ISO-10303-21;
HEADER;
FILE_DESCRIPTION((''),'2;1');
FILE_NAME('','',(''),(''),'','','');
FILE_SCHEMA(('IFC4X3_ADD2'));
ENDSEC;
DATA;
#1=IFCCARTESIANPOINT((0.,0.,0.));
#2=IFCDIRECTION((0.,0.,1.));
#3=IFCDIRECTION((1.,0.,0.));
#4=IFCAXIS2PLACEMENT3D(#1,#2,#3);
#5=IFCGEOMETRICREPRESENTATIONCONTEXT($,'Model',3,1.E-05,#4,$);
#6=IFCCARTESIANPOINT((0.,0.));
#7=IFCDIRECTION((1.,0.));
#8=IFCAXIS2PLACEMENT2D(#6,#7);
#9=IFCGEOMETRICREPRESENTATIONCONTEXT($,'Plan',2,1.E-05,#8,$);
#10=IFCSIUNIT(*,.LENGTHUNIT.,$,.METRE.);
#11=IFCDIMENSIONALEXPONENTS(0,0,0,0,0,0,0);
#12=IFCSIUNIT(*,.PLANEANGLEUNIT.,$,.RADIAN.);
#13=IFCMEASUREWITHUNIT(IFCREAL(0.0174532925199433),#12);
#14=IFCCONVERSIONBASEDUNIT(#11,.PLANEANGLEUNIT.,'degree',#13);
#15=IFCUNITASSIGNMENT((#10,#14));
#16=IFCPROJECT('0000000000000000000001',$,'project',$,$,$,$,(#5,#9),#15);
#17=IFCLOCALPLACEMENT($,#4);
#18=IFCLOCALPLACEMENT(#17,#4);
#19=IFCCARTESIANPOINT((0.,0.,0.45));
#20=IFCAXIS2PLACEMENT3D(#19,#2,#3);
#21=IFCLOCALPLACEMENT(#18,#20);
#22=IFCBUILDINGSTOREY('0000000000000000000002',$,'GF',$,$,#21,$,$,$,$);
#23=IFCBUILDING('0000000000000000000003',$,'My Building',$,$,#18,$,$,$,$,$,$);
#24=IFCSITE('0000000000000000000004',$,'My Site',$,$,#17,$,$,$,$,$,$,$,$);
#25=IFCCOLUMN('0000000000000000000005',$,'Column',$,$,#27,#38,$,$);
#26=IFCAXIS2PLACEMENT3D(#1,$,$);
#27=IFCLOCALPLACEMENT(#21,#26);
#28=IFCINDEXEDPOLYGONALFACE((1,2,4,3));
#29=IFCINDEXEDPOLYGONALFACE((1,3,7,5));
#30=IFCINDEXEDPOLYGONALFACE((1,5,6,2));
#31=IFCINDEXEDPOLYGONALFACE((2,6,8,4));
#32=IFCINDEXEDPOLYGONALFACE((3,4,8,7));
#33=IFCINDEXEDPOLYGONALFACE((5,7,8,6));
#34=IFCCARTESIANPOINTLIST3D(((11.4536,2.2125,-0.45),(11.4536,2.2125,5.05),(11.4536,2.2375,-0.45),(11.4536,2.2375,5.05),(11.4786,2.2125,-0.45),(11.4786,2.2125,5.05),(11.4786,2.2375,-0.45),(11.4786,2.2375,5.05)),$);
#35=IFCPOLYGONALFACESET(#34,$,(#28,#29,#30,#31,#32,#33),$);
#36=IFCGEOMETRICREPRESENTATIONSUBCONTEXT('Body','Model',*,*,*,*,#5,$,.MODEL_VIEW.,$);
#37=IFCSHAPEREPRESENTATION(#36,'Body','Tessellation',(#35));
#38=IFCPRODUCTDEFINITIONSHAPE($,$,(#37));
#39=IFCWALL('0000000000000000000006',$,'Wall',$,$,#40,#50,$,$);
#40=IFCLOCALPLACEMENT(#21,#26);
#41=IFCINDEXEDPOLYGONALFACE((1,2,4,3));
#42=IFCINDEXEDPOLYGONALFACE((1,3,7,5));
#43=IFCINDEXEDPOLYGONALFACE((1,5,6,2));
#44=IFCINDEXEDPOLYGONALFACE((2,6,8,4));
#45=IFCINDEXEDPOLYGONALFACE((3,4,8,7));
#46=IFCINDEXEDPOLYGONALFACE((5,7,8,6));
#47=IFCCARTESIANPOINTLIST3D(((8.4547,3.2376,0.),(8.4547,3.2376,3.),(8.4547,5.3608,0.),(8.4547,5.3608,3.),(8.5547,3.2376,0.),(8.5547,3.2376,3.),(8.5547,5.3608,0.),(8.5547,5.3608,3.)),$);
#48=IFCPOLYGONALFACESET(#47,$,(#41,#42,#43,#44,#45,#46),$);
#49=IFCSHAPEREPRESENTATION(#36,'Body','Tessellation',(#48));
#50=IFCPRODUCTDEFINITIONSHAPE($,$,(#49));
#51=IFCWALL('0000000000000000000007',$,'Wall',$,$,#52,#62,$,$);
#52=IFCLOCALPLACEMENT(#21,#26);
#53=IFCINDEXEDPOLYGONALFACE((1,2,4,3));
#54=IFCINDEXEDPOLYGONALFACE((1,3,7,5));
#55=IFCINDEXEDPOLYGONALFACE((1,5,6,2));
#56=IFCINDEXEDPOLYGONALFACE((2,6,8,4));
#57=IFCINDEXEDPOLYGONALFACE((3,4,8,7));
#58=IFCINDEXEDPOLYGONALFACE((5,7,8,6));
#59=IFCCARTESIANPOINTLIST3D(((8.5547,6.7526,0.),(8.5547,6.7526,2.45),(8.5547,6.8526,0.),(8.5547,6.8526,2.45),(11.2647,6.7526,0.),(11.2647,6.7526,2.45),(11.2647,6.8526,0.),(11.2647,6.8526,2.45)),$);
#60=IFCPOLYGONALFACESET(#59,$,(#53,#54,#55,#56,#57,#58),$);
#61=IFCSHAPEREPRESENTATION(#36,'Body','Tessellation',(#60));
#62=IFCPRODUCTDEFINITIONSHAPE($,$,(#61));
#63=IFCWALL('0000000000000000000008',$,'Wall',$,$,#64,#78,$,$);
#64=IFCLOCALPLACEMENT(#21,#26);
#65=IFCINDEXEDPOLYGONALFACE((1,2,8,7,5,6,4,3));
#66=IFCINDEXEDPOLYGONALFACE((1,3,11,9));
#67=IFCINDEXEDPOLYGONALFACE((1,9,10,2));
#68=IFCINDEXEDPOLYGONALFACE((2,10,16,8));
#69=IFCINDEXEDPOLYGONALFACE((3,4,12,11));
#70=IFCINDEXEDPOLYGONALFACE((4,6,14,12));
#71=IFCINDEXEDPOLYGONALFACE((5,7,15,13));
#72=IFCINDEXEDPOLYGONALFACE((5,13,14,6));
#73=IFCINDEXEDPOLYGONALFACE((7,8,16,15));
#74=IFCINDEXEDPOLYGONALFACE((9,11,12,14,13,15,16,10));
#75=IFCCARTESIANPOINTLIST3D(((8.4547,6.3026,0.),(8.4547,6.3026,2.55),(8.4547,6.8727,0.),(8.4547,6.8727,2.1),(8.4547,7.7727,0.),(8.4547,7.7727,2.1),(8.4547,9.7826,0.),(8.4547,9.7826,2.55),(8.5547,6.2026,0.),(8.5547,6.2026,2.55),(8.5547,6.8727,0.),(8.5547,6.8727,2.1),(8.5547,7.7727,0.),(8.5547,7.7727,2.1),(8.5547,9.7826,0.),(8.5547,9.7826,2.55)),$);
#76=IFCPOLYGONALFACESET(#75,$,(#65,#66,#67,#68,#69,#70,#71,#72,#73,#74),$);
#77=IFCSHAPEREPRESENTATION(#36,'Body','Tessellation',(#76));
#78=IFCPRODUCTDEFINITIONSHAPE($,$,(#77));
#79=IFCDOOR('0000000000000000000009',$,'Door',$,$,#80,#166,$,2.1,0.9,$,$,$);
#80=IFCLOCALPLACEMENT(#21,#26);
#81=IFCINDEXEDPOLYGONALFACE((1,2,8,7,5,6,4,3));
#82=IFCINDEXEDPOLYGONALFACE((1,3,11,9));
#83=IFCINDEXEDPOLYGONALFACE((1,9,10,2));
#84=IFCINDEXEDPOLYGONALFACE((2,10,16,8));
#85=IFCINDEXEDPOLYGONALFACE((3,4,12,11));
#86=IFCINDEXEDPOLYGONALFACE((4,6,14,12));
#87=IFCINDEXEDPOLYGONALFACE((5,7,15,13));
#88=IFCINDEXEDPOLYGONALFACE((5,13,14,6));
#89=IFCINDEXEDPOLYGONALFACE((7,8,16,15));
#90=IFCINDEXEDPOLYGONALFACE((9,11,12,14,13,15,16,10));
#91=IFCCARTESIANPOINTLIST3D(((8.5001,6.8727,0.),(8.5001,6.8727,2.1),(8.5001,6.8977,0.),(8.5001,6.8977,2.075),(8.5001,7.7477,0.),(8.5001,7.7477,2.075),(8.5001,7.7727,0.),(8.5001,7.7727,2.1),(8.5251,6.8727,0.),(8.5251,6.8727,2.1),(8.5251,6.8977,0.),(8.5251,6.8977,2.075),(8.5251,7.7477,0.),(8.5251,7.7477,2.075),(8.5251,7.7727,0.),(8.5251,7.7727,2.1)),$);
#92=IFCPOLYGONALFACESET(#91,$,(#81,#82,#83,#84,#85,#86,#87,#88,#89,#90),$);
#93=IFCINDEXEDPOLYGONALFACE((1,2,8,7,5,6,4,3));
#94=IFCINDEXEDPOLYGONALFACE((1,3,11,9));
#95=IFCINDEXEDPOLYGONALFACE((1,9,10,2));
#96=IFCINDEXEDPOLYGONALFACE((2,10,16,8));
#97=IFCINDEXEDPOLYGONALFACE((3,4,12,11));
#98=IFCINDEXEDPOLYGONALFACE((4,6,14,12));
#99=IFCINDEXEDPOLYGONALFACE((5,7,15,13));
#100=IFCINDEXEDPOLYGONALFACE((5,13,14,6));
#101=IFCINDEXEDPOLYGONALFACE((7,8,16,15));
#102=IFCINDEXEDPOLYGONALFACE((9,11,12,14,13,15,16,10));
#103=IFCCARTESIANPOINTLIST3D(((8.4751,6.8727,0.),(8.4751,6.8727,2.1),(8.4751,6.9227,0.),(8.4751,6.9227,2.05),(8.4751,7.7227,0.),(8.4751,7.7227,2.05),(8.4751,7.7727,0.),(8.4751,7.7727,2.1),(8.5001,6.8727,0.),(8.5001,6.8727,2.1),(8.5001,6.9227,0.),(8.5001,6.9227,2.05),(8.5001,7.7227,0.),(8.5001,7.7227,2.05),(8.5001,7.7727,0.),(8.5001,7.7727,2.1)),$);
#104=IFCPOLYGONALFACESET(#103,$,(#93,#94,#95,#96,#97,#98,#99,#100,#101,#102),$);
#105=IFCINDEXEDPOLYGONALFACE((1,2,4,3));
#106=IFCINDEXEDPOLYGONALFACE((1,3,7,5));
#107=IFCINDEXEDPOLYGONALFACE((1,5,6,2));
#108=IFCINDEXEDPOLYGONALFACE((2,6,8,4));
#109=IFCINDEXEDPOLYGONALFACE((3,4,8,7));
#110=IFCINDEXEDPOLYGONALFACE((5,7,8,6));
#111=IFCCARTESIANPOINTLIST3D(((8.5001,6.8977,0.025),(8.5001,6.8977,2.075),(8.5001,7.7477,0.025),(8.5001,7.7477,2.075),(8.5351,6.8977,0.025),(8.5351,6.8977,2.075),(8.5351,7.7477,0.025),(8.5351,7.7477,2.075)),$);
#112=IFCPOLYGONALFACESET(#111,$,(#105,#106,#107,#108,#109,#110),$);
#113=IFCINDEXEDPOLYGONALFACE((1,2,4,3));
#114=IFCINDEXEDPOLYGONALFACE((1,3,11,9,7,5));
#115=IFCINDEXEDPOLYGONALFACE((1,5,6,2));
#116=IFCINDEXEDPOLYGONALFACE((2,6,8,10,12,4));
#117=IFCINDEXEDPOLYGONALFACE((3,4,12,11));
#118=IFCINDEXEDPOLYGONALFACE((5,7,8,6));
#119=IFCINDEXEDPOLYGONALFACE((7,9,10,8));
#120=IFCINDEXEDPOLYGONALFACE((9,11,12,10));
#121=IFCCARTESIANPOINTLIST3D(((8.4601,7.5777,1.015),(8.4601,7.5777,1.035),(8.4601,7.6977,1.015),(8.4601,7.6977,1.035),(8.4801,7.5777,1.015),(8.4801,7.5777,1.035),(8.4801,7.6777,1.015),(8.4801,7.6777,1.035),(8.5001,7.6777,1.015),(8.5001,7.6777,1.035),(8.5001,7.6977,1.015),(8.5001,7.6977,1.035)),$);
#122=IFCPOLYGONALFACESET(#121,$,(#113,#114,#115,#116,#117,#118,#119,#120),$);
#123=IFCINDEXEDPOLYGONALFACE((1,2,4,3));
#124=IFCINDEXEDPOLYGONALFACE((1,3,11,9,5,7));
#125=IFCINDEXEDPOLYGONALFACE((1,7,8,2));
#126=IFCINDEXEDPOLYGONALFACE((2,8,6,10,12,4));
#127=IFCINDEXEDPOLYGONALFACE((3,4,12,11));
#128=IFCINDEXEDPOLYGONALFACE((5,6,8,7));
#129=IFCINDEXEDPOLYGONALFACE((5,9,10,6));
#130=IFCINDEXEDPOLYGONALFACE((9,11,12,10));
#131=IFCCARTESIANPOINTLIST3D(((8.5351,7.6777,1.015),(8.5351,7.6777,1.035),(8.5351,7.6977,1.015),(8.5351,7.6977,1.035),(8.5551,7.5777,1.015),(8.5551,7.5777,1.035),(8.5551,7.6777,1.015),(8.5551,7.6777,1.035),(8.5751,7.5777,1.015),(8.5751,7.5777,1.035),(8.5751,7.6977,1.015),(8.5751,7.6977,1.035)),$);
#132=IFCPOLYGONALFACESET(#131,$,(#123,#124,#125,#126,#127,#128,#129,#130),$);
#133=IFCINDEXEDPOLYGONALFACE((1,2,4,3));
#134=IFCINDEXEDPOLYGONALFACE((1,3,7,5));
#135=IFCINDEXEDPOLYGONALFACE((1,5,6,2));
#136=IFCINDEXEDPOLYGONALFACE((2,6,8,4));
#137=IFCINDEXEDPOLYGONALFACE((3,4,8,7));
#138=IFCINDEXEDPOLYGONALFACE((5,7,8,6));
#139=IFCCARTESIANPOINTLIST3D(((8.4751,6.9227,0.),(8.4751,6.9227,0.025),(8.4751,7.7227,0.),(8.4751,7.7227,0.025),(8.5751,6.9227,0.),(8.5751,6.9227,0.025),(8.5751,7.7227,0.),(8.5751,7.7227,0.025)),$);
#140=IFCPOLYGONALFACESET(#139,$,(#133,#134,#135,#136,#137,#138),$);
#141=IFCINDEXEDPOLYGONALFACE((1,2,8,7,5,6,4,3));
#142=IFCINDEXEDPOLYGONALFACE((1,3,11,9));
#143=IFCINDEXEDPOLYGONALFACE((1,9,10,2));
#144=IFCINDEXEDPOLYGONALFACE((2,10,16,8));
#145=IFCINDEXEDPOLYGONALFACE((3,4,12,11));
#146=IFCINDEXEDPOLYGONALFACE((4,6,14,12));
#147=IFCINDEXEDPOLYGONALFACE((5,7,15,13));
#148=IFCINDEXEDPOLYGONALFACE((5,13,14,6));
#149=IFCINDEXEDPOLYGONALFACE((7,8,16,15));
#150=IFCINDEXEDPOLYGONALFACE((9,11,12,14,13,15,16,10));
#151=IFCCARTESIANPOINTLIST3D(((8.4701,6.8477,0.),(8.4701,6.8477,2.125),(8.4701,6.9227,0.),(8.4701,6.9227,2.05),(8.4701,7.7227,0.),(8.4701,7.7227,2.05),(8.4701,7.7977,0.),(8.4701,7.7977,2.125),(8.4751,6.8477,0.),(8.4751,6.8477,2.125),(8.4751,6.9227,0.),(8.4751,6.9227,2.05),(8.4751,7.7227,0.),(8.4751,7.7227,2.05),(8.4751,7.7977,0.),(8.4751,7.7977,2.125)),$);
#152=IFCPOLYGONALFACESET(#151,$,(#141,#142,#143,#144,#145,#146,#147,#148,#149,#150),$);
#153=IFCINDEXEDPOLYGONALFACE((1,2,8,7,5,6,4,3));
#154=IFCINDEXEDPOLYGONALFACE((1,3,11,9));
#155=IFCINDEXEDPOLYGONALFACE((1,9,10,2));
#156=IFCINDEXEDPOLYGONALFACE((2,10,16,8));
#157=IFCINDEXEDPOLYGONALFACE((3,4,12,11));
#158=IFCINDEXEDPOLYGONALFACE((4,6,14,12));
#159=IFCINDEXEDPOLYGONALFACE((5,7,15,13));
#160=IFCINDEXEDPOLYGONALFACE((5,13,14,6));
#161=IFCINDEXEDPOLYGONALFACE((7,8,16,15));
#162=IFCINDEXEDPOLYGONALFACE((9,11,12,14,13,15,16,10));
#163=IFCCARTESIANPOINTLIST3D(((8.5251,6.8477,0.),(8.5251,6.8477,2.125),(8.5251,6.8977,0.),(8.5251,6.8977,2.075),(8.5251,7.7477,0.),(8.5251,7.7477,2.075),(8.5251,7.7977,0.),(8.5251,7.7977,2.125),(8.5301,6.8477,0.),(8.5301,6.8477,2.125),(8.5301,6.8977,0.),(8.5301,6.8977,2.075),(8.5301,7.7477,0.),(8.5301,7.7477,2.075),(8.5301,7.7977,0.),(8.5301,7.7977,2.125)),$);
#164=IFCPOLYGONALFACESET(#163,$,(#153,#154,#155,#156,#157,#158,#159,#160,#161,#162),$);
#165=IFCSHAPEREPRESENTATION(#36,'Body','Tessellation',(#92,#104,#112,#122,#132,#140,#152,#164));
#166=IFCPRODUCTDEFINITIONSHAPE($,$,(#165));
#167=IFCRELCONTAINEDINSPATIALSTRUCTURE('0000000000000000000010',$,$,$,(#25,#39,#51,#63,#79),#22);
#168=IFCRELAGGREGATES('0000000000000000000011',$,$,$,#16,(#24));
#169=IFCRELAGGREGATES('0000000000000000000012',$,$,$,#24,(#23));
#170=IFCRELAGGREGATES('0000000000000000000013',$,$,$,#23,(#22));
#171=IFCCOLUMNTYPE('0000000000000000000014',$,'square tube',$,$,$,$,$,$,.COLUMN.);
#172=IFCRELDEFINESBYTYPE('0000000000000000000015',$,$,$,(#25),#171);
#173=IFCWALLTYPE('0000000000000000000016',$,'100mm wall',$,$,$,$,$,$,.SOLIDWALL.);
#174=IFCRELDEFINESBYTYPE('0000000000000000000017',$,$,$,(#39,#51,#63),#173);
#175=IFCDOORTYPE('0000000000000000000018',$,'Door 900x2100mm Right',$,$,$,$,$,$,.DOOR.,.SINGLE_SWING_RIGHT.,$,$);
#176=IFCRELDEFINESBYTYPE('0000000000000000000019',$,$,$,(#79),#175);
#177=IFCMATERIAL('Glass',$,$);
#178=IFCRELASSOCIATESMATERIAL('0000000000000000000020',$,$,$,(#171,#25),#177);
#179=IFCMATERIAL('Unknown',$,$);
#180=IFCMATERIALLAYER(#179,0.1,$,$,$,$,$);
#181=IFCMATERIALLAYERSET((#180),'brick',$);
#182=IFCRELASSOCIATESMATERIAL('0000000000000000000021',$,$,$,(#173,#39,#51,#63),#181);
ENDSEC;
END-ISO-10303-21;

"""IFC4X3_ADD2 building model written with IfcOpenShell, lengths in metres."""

from ifc_helpers import new_model, entity, si_unit, converted_unit, frame, origin_with_axes, origin_2d_with_axis, place, context, subcontext, project, spatial, line, indexed_curve, rectangle, outline, extrude, shape, source, transform, mapped, material, layer, layer_set, layer_usage, material_profile, profile_set, profile_usage, type_object, type_shapes, element, fill, save


model = new_model("IFC4X3_ADD2")

# Units and contexts
model_context = context("Model", 3, precision=1e-05, world=origin_with_axes())
plan_context = context("Plan", 2, precision=1e-05, world=origin_2d_with_axis())
body_context_1 = subcontext(model_context, "Body", "Model", "MODEL_VIEW")
body_context_2 = subcontext(plan_context, "Body", "Plan", "PLAN_VIEW")
ifc_project = project(units=[si_unit("LENGTHUNIT", "METRE"), converted_unit("PLANEANGLEUNIT", "degree", entity("IfcReal", 0.0174532925199433), si_unit("PLANEANGLEUNIT", "RADIAN"), dimensions=[0, 0, 0, 0, 0, 0, 0])], contexts=[model_context, plan_context])

# Site, building, storey
site_placement = place(None, origin_with_axes())
site = spatial("IfcSite", under=ifc_project, at=site_placement, Name="My Site")
building_placement = place(site_placement, origin_with_axes())
building = spatial("IfcBuilding", under=site, at=building_placement, Name="My Building")
storey_placement = place(building_placement, frame((0.0, 0.0, 0.45), z_axis=(0.0, 0.0, 1.0), x_axis=(1.0, 0.0, 0.0)))
storey = spatial("IfcBuildingStorey", under=building, at=storey_placement, Name="GF")

# Column
ifc_material_1 = material(Name="Glass")
ifc_material_profile = material_profile(ifc_material_1, rectangle(XDim=0.025, YDim=0.025))
ifc_profile_set = profile_set([ifc_material_profile])
column_type = type_object("IfcColumnType", Name="square tube", PredefinedType="COLUMN", material=ifc_profile_set)
ifc_profile_usage_1 = profile_usage(ifc_profile_set, cardinal=5)
column_1_placement = place(storey_placement, frame((11.4661, 2.225, -0.45), z_axis=(0.0, 0.0, 1.0), x_axis=(1.0, 0.0, 0.0)))
element("IfcColumn", 1, at=column_1_placement, inside=storey, type_object=column_type, material=ifc_profile_usage_1, Name="Column", context=body_context_1, shape_type="SweptSolid", body=[
    extrude(rectangle(XDim=0.025, YDim=0.025), origin_with_axes(), (0.0, 0.0, 1.0), 5.5),
])

# Walls
ifc_material_2 = material(Name="Unknown")
ifc_layer = layer(ifc_material_2, 0.1)
ifc_layer_set = layer_set([ifc_layer], Name="brick")
ifc_layer_usage_1 = layer_usage(ifc_layer_set, "AXIS2", "POSITIVE", 0.0)
wall_type = type_object("IfcWallType", Name="100mm wall", PredefinedType="SOLIDWALL", material=ifc_layer_set)
wall_1_placement = place(storey_placement, frame((8.5547, 3.2376, 0.0), z_axis=(0.0, 0.0, 1.0), x_axis=(0.0, 1.0, 0.0)))
element("IfcWall", 2, at=wall_1_placement, inside=storey, type_object=wall_type, material=ifc_layer_usage_1, Name="Wall", context=body_context_1, shape_type="SweptSolid", body=[
    extrude(outline(indexed_curve([(0.0, 0.0), (0.0, 0.1), (2.1232, 0.1), (2.1232, 0.0), (0.0, 0.0)], self_intersect=False)), origin_with_axes(), (0.0, 0.0, 1.0), 3.0),
])
ifc_layer_usage_2 = layer_usage(ifc_layer_set, "AXIS2", "POSITIVE", 0.0)
wall_2_placement = place(storey_placement, frame((8.5547, 6.7526, 0.0), z_axis=(0.0, 0.0, 1.0), x_axis=(1.0, 0.0, 0.0)))
element("IfcWall", 3, at=wall_2_placement, inside=storey, type_object=wall_type, material=ifc_layer_usage_2, Name="Wall", context=body_context_1, shape_type="SweptSolid", body=[
    extrude(outline(indexed_curve([(0.0, 0.0), (0.0, 0.1), (2.71, 0.1), (2.71, 0.0)], segments=[line(1, 2, 3, 4, 1)])), origin_with_axes(), (0.0, 0.0, 1.0), 2.45),
])

# Wall, opening, door
ifc_layer_usage_3 = layer_usage(ifc_layer_set, "AXIS2", "POSITIVE", 0.0)
wall_3_placement = place(storey_placement, frame((8.5547, 6.2026, 0.0), z_axis=(0.0, 0.0, 1.0), x_axis=(0.0, 1.0, 0.0)))
wall_3 = element("IfcWall", 4, at=wall_3_placement, inside=storey, type_object=wall_type, material=ifc_layer_usage_3, Name="Wall", context=body_context_1, shape_type="SweptSolid", body=[
    extrude(outline(indexed_curve([(0.0, 0.0), (0.1, 0.1), (3.58, 0.1), (3.58, 0.0)], segments=[line(1, 2, 3, 4, 1)])), origin_with_axes(), (0.0, 0.0, 1.0), 2.55),
])
shared_shape_1 = source(origin_with_axes(), body_context_1, "Body", "SolidModel", [
    extrude(outline(indexed_curve([(0.0, 0.0), (0.9, 0.0), (0.9, 2.1), (0.0, 2.1)], segments=[line(1, 2, 3, 4, 1)])), frame((0.0, -0.6, 0.0), z_axis=(0.0, -1.0, 0.0), x_axis=(1.0, 0.0, 0.0)), (0.0, 0.0, -1.0), 1.2),
])
opening_placement = place(wall_3_placement, frame((1.5702, 0.0796, 0.0), z_axis=(0.0, 0.0, 1.0), x_axis=(-1.0, 0.0, 0.0)))
opening = element("IfcOpeningElement", 5, at=opening_placement, cuts=wall_3, PredefinedType="OPENING", context=body_context_1, shape_type="MappedRepresentation", body=[
    mapped(shared_shape_1, transform((0.0, 0.0, 0.0), x_axis=(1.0, 0.0, 0.0), y_axis=(0.0, 1.0, 0.0), z_axis=(0.0, 0.0, 1.0), scale=1.0)),
])
door_type = type_object("IfcDoorType", Name="Door 900x2100mm Right", OperationType="SINGLE_SWING_RIGHT", PredefinedType="DOOR")
shared_shape_2 = source(origin_with_axes(), body_context_1, "Body", "SweptSolid", [
    extrude(outline(indexed_curve([(0.0, 0.0), (0.0, 2.1), (0.9, 2.1), (0.9, 0.0), (0.875, 0.0), (0.875, 2.075), (0.025, 2.075), (0.025, 0.0)], segments=[line(1, 2, 3, 4, 5, 6, 7, 8, 1)])), frame((0.0, 0.025, 0.0), z_axis=(0.0, -1.0, 0.0), x_axis=(1.0, 0.0, 0.0)), (0.0, 0.0, -1.0), 0.025),
    extrude(outline(indexed_curve([(0.0, 0.0), (0.0, 2.1), (0.9, 2.1), (0.9, 0.0), (0.85, 0.0), (0.85, 2.05), (0.05, 2.05), (0.05, 0.0)], segments=[line(1, 2, 3, 4, 5, 6, 7, 8, 1)])), frame((0.0, 0.0, 0.0), z_axis=(0.0, -1.0, 0.0), x_axis=(1.0, 0.0, 0.0)), (0.0, 0.0, -1.0), 0.025),
    extrude(outline(indexed_curve([(0.0, 0.0), (0.85, 0.0), (0.85, 0.035), (0.0, 0.035)], segments=[line(1, 2, 3, 4, 1)])), frame((0.025, 0.025, 0.025), z_axis=(0.0, 0.0, 1.0), x_axis=(1.0, 0.0, 0.0)), (0.0, 0.0, 1.0), 2.05),
    extrude(outline(indexed_curve([(0.0, 0.0), (0.0, -0.04), (0.12, -0.04), (0.12, -0.02), (0.02, -0.02), (0.02, 0.0)], segments=[line(1, 2, 3, 4, 5, 6, 1)])), frame((0.075, 0.025, 1.015), z_axis=(0.0, 0.0, 1.0), x_axis=(1.0, 0.0, 0.0)), (0.0, 0.0, 1.0), 0.02),
    extrude(outline(indexed_curve([(0.0, 0.0), (0.0, 0.04), (0.12, 0.04), (0.12, 0.02), (0.02, 0.02), (0.02, 0.0)], segments=[line(1, 2, 3, 4, 5, 6, 1)])), frame((0.075, 0.06, 1.015), z_axis=(0.0, 0.0, 1.0), x_axis=(1.0, 0.0, 0.0)), (0.0, 0.0, 1.0), 0.02),
    extrude(outline(indexed_curve([(0.0, 0.0), (0.8, 0.0), (0.8, 0.1), (0.0, 0.1)], segments=[line(1, 2, 3, 4, 1)])), frame((0.05, 0.0, 0.0), z_axis=(0.0, 0.0, 1.0), x_axis=(1.0, 0.0, 0.0)), (0.0, 0.0, 1.0), 0.025),
    extrude(outline(indexed_curve([(0.0, 0.0), (0.0, 2.125), (0.95, 2.125), (0.95, 0.0), (0.875, 0.0), (0.875, 2.05), (0.075, 2.05), (0.075, 0.0)], segments=[line(1, 2, 3, 4, 5, 6, 7, 8, 1)])), frame((-0.025, -0.005, 0.0), z_axis=(0.0, -1.0, 0.0), x_axis=(1.0, 0.0, 0.0)), (0.0, 0.0, -1.0), 0.005),
    extrude(outline(indexed_curve([(0.0, 0.0), (0.0, 2.125), (0.95, 2.125), (0.95, 0.0), (0.9, 0.0), (0.9, 2.075), (0.05, 2.075), (0.05, 0.0)], segments=[line(1, 2, 3, 4, 5, 6, 7, 8, 1)])), frame((-0.025, 0.05, 0.0), z_axis=(0.0, -1.0, 0.0), x_axis=(1.0, 0.0, 0.0)), (0.0, 0.0, -1.0), 0.005),
])
shared_shape_3 = source(origin_with_axes(), body_context_2, "Body", "Curve2D", [
    entity("IfcIndexedPolyCurve", entity("IfcCartesianPointList2D", [[0.0, 0.0], [0.0, 0.05], [0.025, 0.05], [0.025, 0.025], [0.05, 0.025], [0.05, 0.0]]), [entity("IfcLineIndex", [1, 2, 3, 4, 5, 6, 1])]),
    entity("IfcIndexedPolyCurve", entity("IfcCartesianPointList2D", [[0.9, 0.0], [0.9, 0.05], [0.875, 0.05], [0.875, 0.025], [0.85, 0.025], [0.85, 0.0]]), [entity("IfcLineIndex", [1, 2, 3, 4, 5, 6, 1])]),
    entity("IfcTrimmedCurve", entity("IfcEllipse", entity("IfcAxis2Placement2D", entity("IfcCartesianPoint", [0.84, 0.05]), entity("IfcDirection", [1.0, 0.0])), 0.815, 0.85), [entity("IfcCartesianPoint", [0.84, 0.9])], [entity("IfcCartesianPoint", [0.025, 0.05])], True, "CARTESIAN"),
    entity("IfcIndexedPolyCurve", entity("IfcCartesianPointList2D", [[0.875, 0.05], [0.84, 0.05], [0.84, 0.9], [0.875, 0.9]]), [entity("IfcLineIndex", [1, 2, 3, 4, 1])]),
])
type_shapes(door_type, [shared_shape_2, shared_shape_3])
door_placement = place(opening_placement, frame((0.0, 0.0, 0.0), z_axis=(0.0, 0.0, 1.0), x_axis=(1.0, 0.0, 0.0)))
door = element("IfcDoor", 6, at=door_placement, inside=storey, type_object=door_type, Name="Door", OverallHeight=2.1, OverallWidth=0.9, shapes=[
    shape(body_context_1, "Body", "MappedRepresentation", [mapped(shared_shape_2, transform((0.0, 0.0, 0.0), x_axis=(1.0, 0.0, 0.0), y_axis=(0.0, 1.0, 0.0), z_axis=(0.0, 0.0, 1.0), scale=1.0))]),
    shape(body_context_2, "Body", "MappedRepresentation", [mapped(shared_shape_3, transform((0.0, 0.0, 0.0), x_axis=(1.0, 0.0, 0.0), y_axis=(0.0, 1.0, 0.0), z_axis=(0.0, 0.0, 1.0), scale=1.0))]),
])
fill(opening, door)

save(model, "model.ifc")
